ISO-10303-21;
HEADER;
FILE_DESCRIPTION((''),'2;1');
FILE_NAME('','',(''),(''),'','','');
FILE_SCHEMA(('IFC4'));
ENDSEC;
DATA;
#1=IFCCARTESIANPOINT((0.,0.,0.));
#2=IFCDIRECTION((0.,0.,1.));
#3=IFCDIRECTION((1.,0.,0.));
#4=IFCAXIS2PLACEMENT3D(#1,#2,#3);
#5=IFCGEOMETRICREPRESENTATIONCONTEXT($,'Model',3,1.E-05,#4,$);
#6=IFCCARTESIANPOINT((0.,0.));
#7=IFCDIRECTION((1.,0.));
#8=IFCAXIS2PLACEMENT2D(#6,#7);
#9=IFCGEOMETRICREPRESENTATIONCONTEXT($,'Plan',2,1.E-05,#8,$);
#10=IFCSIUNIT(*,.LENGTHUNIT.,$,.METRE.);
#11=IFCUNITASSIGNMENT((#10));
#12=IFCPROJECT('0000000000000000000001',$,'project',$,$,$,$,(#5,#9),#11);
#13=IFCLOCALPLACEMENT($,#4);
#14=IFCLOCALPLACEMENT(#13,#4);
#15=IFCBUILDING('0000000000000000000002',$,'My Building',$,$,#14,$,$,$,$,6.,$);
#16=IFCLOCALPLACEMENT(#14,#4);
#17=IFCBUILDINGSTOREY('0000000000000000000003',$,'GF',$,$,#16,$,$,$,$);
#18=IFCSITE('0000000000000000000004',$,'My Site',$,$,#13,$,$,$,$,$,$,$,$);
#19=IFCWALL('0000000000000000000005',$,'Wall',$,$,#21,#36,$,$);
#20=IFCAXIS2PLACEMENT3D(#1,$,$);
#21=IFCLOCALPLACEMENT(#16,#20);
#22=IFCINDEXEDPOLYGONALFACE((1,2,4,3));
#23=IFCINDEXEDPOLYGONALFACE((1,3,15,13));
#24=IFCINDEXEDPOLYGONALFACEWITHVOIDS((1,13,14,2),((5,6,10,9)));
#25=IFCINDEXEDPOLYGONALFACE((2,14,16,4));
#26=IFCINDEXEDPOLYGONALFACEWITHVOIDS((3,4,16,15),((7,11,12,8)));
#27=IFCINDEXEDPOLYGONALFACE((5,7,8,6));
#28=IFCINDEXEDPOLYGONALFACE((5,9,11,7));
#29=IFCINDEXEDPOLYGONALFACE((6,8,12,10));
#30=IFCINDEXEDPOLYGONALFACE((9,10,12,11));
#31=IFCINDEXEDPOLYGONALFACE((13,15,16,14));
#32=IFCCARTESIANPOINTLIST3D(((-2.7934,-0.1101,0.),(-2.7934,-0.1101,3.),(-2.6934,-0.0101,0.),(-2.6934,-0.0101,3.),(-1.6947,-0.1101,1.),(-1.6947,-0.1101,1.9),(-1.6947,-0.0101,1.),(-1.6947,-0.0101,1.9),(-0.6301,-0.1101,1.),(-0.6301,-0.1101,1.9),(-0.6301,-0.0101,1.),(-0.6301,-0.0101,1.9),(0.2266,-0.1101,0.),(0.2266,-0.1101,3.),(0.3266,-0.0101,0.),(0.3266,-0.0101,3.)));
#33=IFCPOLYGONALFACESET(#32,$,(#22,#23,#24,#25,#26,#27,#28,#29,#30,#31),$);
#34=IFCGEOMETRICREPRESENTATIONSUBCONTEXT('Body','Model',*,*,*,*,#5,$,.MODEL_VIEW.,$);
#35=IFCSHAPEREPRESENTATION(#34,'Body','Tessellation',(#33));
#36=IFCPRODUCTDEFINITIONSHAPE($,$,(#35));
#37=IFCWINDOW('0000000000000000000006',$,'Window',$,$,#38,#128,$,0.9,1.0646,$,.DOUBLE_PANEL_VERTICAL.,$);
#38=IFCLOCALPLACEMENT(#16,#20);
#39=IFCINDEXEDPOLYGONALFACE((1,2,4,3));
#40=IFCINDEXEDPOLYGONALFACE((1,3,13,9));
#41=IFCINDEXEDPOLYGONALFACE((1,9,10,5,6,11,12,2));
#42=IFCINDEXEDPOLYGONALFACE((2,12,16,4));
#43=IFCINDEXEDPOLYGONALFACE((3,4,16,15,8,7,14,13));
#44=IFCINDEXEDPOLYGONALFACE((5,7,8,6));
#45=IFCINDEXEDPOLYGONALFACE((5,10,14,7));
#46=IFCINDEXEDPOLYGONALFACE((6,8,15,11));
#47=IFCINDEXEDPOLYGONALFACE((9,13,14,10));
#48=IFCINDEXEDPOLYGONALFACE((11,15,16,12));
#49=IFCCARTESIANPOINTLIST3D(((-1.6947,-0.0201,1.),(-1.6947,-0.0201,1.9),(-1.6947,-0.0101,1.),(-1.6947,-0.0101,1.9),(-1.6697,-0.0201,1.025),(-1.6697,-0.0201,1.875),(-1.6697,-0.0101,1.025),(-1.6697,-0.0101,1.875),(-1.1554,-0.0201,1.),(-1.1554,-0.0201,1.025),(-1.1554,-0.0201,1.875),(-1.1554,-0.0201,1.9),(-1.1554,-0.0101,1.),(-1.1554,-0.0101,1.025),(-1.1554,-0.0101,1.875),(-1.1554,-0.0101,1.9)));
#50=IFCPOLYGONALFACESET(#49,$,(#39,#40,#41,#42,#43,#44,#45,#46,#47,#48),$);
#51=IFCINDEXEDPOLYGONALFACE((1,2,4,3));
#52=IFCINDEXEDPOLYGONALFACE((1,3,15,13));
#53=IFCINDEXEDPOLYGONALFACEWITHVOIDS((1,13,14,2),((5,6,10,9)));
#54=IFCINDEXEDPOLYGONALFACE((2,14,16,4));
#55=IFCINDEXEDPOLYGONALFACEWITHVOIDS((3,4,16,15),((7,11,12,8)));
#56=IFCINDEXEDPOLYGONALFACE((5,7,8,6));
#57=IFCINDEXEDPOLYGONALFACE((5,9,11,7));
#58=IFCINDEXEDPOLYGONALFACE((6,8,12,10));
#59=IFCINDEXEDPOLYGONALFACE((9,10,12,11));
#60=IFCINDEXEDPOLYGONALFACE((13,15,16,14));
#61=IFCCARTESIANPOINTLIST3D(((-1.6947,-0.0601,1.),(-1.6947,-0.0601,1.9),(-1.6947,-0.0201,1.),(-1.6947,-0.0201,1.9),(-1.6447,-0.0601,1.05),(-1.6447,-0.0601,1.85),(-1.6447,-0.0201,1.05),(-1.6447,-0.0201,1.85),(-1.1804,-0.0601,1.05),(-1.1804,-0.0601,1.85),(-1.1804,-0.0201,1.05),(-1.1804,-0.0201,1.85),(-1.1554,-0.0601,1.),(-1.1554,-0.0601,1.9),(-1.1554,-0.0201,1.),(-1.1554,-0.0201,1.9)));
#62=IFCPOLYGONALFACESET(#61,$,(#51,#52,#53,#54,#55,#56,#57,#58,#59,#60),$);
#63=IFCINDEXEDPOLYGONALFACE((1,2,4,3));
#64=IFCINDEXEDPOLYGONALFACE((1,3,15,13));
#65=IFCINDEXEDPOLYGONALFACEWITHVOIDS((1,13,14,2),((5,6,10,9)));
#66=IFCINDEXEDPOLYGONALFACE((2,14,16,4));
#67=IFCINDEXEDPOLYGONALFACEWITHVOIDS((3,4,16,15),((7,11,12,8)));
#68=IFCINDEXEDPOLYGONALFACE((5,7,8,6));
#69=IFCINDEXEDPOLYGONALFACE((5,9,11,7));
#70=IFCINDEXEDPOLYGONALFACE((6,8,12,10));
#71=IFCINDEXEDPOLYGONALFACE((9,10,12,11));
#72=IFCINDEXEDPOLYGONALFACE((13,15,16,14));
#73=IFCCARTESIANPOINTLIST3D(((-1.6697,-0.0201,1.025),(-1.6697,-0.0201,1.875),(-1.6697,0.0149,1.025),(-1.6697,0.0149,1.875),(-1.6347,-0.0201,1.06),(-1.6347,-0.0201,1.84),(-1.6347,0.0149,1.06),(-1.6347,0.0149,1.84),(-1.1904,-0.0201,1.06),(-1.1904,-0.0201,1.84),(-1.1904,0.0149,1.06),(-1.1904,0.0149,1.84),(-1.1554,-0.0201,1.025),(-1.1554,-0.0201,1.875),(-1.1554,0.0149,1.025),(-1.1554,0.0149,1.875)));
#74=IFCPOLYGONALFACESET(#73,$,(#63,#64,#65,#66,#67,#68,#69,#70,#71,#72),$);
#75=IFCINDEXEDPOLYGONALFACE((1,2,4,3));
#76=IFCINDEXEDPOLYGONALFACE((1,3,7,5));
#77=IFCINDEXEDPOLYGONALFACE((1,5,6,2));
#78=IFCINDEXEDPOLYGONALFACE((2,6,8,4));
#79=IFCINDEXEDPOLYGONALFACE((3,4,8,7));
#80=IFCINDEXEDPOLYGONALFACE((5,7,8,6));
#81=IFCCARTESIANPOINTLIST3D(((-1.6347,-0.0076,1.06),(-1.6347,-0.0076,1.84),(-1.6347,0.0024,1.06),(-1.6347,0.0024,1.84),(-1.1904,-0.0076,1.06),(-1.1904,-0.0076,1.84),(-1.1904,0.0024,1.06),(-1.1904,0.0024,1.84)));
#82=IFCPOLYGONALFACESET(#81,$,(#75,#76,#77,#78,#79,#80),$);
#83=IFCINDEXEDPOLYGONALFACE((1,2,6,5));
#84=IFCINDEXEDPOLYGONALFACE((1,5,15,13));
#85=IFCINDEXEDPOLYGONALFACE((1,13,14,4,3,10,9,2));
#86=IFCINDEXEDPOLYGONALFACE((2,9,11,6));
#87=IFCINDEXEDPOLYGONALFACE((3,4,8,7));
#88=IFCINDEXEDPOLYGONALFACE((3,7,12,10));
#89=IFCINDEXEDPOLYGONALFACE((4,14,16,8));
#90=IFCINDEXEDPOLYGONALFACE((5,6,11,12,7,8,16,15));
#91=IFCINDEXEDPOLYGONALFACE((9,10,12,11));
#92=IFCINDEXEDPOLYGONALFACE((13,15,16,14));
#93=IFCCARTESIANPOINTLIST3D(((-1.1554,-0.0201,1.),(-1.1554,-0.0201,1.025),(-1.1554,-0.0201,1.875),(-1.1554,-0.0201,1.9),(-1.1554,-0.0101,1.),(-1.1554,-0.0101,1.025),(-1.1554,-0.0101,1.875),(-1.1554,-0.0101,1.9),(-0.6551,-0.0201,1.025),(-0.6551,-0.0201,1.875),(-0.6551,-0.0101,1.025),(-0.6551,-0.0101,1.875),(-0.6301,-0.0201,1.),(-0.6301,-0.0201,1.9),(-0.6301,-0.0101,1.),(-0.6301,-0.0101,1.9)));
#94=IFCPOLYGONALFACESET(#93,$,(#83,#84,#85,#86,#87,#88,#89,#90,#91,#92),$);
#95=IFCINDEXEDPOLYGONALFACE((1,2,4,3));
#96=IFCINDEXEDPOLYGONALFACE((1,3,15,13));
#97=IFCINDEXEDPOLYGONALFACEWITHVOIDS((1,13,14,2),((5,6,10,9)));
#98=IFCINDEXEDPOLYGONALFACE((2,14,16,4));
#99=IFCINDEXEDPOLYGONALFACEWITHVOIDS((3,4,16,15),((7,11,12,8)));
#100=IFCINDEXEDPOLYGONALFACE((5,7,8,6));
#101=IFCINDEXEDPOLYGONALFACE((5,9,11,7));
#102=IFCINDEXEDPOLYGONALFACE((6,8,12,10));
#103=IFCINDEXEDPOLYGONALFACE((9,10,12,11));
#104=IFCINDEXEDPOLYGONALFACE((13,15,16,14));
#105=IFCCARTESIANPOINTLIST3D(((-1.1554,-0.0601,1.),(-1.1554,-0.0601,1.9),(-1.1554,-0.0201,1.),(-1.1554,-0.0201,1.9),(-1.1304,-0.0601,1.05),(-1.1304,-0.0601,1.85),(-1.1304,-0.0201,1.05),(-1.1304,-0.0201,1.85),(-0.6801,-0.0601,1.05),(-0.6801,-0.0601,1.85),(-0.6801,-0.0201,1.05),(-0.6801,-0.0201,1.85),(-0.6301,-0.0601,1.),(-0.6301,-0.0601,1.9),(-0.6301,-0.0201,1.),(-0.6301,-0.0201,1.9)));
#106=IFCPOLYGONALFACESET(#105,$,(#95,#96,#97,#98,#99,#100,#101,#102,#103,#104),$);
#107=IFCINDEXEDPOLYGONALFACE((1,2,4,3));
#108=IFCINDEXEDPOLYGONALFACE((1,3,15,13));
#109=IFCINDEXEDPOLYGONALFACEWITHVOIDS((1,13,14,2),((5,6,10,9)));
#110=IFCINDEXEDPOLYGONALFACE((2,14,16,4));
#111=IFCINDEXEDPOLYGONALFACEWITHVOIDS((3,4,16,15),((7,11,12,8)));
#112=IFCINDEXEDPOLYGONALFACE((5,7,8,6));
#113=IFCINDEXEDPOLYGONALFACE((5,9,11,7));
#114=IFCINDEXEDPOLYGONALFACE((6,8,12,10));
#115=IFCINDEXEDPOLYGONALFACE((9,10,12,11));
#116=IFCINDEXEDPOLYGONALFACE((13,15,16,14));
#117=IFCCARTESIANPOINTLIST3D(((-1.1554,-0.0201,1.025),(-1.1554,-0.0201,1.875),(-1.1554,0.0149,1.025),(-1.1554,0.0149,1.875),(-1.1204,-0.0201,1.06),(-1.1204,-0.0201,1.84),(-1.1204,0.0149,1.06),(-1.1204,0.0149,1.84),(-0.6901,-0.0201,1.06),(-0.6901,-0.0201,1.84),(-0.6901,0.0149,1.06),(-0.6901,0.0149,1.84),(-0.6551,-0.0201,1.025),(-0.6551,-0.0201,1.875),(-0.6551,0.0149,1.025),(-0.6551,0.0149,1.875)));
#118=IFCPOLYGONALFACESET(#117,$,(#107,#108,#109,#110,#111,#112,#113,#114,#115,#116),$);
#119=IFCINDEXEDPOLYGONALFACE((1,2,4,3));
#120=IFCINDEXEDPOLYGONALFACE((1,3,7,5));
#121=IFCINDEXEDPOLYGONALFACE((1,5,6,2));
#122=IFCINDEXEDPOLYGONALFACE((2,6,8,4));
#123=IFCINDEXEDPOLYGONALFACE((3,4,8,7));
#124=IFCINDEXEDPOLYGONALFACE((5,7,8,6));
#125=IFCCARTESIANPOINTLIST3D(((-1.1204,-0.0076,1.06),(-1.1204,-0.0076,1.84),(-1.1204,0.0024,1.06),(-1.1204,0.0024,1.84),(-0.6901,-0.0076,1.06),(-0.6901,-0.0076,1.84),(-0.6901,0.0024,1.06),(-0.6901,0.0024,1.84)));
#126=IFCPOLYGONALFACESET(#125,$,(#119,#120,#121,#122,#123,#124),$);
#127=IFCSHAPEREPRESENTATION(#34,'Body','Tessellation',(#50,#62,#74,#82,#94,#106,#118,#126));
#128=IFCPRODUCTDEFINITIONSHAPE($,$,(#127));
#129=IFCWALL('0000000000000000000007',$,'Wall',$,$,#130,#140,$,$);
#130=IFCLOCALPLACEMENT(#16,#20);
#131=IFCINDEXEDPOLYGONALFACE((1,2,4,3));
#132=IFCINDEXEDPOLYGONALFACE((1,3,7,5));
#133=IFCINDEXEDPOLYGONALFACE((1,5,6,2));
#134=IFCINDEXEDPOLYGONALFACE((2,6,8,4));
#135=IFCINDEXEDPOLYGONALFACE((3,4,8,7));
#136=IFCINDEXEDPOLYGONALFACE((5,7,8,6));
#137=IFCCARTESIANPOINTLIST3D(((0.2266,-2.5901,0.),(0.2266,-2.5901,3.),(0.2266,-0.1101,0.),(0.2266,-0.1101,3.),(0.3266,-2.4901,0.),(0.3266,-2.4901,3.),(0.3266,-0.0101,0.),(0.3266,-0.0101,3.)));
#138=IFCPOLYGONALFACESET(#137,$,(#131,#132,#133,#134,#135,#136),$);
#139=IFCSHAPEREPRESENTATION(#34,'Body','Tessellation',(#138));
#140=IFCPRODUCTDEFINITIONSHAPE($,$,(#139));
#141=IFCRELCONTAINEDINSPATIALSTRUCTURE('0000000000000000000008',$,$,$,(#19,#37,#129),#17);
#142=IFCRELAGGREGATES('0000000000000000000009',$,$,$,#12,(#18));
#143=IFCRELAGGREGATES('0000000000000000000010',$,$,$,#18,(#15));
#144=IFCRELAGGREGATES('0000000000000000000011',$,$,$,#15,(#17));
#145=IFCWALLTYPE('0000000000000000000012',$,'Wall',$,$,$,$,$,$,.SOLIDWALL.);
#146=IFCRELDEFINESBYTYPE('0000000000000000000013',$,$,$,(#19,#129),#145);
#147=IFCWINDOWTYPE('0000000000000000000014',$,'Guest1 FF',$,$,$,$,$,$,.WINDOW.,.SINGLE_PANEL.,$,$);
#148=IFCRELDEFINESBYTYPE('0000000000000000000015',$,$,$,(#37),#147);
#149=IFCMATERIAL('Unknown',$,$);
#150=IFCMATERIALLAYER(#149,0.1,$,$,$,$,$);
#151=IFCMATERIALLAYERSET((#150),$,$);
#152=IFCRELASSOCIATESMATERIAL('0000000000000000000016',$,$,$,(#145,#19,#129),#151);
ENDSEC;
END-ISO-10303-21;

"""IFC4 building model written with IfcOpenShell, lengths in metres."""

from ifc_helpers import new_model, entity, si_unit, frame, origin_with_axes, origin_2d_with_axis, place, context, subcontext, project, spatial, line, indexed_curve, outline, extrude, shape, source, transform, mapped, material, layer, layer_set, layer_usage, type_object, type_shapes, element, fill, save


model = new_model("IFC4")

# Units and contexts
model_context = context("Model", 3, precision=1e-05, world=origin_with_axes())
plan_context = context("Plan", 2, precision=1e-05, world=origin_2d_with_axis())
body_context_1 = subcontext(model_context, "Body", "Model", "MODEL_VIEW")
body_context_2 = subcontext(plan_context, "Body", "Plan", "PLAN_VIEW")
ifc_project = project(units=[si_unit("LENGTHUNIT", "METRE")], contexts=[model_context, plan_context])

# Site, building, storey
site_placement = place(None, origin_with_axes())
site = spatial("IfcSite", under=ifc_project, at=site_placement, Name="My Site")
building_placement = place(site_placement, origin_with_axes())
building = spatial("IfcBuilding", under=site, at=building_placement, Name="My Building", ElevationOfTerrain=6.0)
storey_placement = place(building_placement, origin_with_axes())
storey = spatial("IfcBuildingStorey", under=building, at=storey_placement, Name="GF")

# Shared definitions
ifc_material_1 = material(Name="Unknown")
ifc_layer = layer(ifc_material_1, 0.1)
ifc_layer_set = layer_set([ifc_layer])
wall_type = type_object("IfcWallType", Name="Wall", PredefinedType="SOLIDWALL", material=ifc_layer_set)

# Wall, opening, window
ifc_layer_usage_1 = layer_usage(ifc_layer_set, "AXIS2", "POSITIVE", 0.0)
wall_1_placement = place(storey_placement, frame((-2.7934, -0.1101, 0.0), z_axis=(0.0, 0.0, 1.0), x_axis=(1.0, 0.0, 0.0)))
wall_1 = element("IfcWall", 1, at=wall_1_placement, inside=storey, type_object=wall_type, material=ifc_layer_usage_1, Name="Wall", context=body_context_1, shape_type="SweptSolid", body=[
    extrude(outline(indexed_curve([(0.0, 0.0), (0.1, 0.1), (3.12, 0.1), (3.02, 0.0)], segments=[line(1, 2, 3, 4, 1)])), origin_with_axes(), (0.0, 0.0, 1.0), 3.0),
])
shared_shape_1 = source(origin_with_axes(), body_context_1, "Body", "SweptSolid", [
    extrude(outline(indexed_curve([(0.0, 0.0), (1.0646, 0.0), (1.0646, 0.9), (0.0, 0.9)], segments=[line(1, 2, 3, 4, 1)])), frame((0.0, -0.6, 0.0), z_axis=(0.0, -1.0, 0.0), x_axis=(1.0, 0.0, 0.0)), (0.0, 0.0, -1.0), 1.2),
])
opening_1_placement = place(wall_1_placement, frame((1.0987, 0.0, 1.0), z_axis=(0.0, 0.0, 1.0), x_axis=(1.0, 0.0, 0.0)))
opening_1 = element("IfcOpeningElement", 2, at=opening_1_placement, cuts=wall_1, PredefinedType="OPENING", context=body_context_1, shape_type="MappedRepresentation", body=[
    mapped(shared_shape_1, transform((0.0, 0.0, 0.0), x_axis=(1.0, 0.0, 0.0), y_axis=(0.0, 1.0, 0.0), z_axis=(0.0, 0.0, 1.0), scale=1.0)),
])
window_type_1 = type_object("IfcWindowType", Name="Guest1 FF", PartitioningType="SINGLE_PANEL", PredefinedType="WINDOW")
shared_shape_2 = source(origin_with_axes(), body_context_1, "Body", "SweptSolid", [
    extrude(outline(indexed_curve([(0.5393, 0.0), (0.0, 0.0), (0.0, 0.9), (0.5393, 0.9), (0.5393, 0.875), (0.025, 0.875), (0.025, 0.025), (0.5393, 0.025)], segments=[line(1, 2, 3, 4, 5, 6, 7, 8, 1)])), frame((0.0, 0.09, 0.0), z_axis=(0.0, -1.0, 0.0), x_axis=(1.0, 0.0, 0.0)), (0.0, 0.0, -1.0), 0.01),
    extrude(outline(indexed_curve([(0.0, 0.0), (0.5393, 0.0), (0.5393, 0.9), (0.0, 0.9)], segments=[line(1, 2, 3, 4, 1)]), holes=[indexed_curve([(0.05, 0.05), (0.5143, 0.05), (0.5143, 0.85), (0.05, 0.85)], segments=[line(1, 2, 3, 4, 1)])]), frame((0.0, 0.05, 0.0), z_axis=(0.0, -1.0, 0.0), x_axis=(1.0, 0.0, 0.0)), (0.0, 0.0, -1.0), 0.04),
    extrude(outline(indexed_curve([(0.0, 0.0), (0.5143, 0.0), (0.5143, 0.85), (0.0, 0.85)], segments=[line(1, 2, 3, 4, 1)]), holes=[indexed_curve([(0.035, 0.035), (0.4793, 0.035), (0.4793, 0.815), (0.035, 0.815)], segments=[line(1, 2, 3, 4, 1)])]), frame((0.025, 0.09, 0.025), z_axis=(0.0, -1.0, 0.0), x_axis=(1.0, 0.0, 0.0)), (0.0, 0.0, -1.0), 0.035),
    extrude(outline(indexed_curve([(0.035, 0.035), (0.4793, 0.035), (0.4793, 0.815), (0.035, 0.815)], segments=[line(1, 2, 3, 4, 1)])), frame((0.025, 0.1025, 0.025), z_axis=(0.0, -1.0, 0.0), x_axis=(1.0, 0.0, 0.0)), (0.0, 0.0, -1.0), 0.01),
    extrude(outline(indexed_curve([(0.0, 0.9), (0.5253, 0.9), (0.5253, 0.0), (0.0, 0.0), (0.0, 0.025), (0.5003, 0.025), (0.5003, 0.875), (0.0, 0.875)], segments=[line(1, 2, 3, 4, 5, 6, 7, 8, 1)])), frame((0.5393, 0.09, 0.0), z_axis=(0.0, -1.0, 0.0), x_axis=(1.0, 0.0, 0.0)), (0.0, 0.0, -1.0), 0.01),
    extrude(outline(indexed_curve([(0.0, 0.0), (0.5253, 0.0), (0.5253, 0.9), (0.0, 0.9)], segments=[line(1, 2, 3, 4, 1)]), holes=[indexed_curve([(0.025, 0.05), (0.4753, 0.05), (0.4753, 0.85), (0.025, 0.85)], segments=[line(1, 2, 3, 4, 1)])]), frame((0.5393, 0.05, 0.0), z_axis=(0.0, -1.0, 0.0), x_axis=(1.0, 0.0, 0.0)), (0.0, 0.0, -1.0), 0.04),
    extrude(outline(indexed_curve([(0.0, 0.0), (0.5003, 0.0), (0.5003, 0.85), (0.0, 0.85)], segments=[line(1, 2, 3, 4, 1)]), holes=[indexed_curve([(0.035, 0.035), (0.4653, 0.035), (0.4653, 0.815), (0.035, 0.815)], segments=[line(1, 2, 3, 4, 1)])]), frame((0.5393, 0.09, 0.025), z_axis=(0.0, -1.0, 0.0), x_axis=(1.0, 0.0, 0.0)), (0.0, 0.0, -1.0), 0.035),
    extrude(outline(indexed_curve([(0.035, 0.035), (0.4653, 0.035), (0.4653, 0.815), (0.035, 0.815)], segments=[line(1, 2, 3, 4, 1)])), frame((0.5393, 0.1025, 0.025), z_axis=(0.0, -1.0, 0.0), x_axis=(1.0, 0.0, 0.0)), (0.0, 0.0, -1.0), 0.01),
])
shared_shape_3 = source(origin_with_axes(), body_context_2, "Body", "Curve2D", [
    entity("IfcIndexedPolyCurve", entity("IfcCartesianPointList2D", [[0.05, 0.05], [0.5143, 0.05]])),
    entity("IfcIndexedPolyCurve", entity("IfcCartesianPointList2D", [[0.0, 0.1], [0.025, 0.1], [0.025, 0.09], [0.05, 0.09], [0.05, 0.05], [0.0, 0.05]]), [entity("IfcLineIndex", [1, 2, 3, 4, 5, 6, 1])]),
    entity("IfcIndexedPolyCurve", entity("IfcCartesianPointList2D", [[0.5393, 0.1], [0.5393, 0.1], [0.5393, 0.09], [0.5143, 0.09], [0.5143, 0.05], [0.5393, 0.05]])),
    entity("IfcIndexedPolyCurve", entity("IfcCartesianPointList2D", [[0.025, 0.09], [0.06, 0.09], [0.06, 0.125], [0.025, 0.125]]), [entity("IfcLineIndex", [1, 2, 3, 4, 1])]),
    entity("IfcIndexedPolyCurve", entity("IfcCartesianPointList2D", [[0.5393, 0.09], [0.5043, 0.09], [0.5043, 0.125], [0.5393, 0.125]]), [entity("IfcLineIndex", [1, 2, 3, 4, 1])]),
    entity("IfcIndexedPolyCurve", entity("IfcCartesianPointList2D", [[0.06, 0.09], [0.5043, 0.09]])),
    entity("IfcIndexedPolyCurve", entity("IfcCartesianPointList2D", [[0.06, 0.125], [0.5043, 0.125]])),
    entity("IfcIndexedPolyCurve", entity("IfcCartesianPointList2D", [[0.06, 0.1075], [0.5043, 0.1075]])),
    entity("IfcIndexedPolyCurve", entity("IfcCartesianPointList2D", [[0.5643, 0.05], [1.0146, 0.05]])),
    entity("IfcIndexedPolyCurve", entity("IfcCartesianPointList2D", [[0.5393, 0.1], [0.5393, 0.1], [0.5393, 0.09], [0.5643, 0.09], [0.5643, 0.05], [0.5393, 0.05]])),
    entity("IfcIndexedPolyCurve", entity("IfcCartesianPointList2D", [[1.0646, 0.1], [1.0396, 0.1], [1.0396, 0.09], [1.0146, 0.09], [1.0146, 0.05], [1.0646, 0.05]]), [entity("IfcLineIndex", [1, 2, 3, 4, 5, 6, 1])]),
    entity("IfcIndexedPolyCurve", entity("IfcCartesianPointList2D", [[0.5393, 0.09], [0.5743, 0.09], [0.5743, 0.125], [0.5393, 0.125]]), [entity("IfcLineIndex", [1, 2, 3, 4, 1])]),
    entity("IfcIndexedPolyCurve", entity("IfcCartesianPointList2D", [[1.0396, 0.09], [1.0046, 0.09], [1.0046, 0.125], [1.0396, 0.125]]), [entity("IfcLineIndex", [1, 2, 3, 4, 1])]),
    entity("IfcIndexedPolyCurve", entity("IfcCartesianPointList2D", [[0.5743, 0.09], [1.0046, 0.09]])),
    entity("IfcIndexedPolyCurve", entity("IfcCartesianPointList2D", [[0.5743, 0.125], [1.0046, 0.125]])),
    entity("IfcIndexedPolyCurve", entity("IfcCartesianPointList2D", [[0.5743, 0.1075], [1.0046, 0.1075]])),
])
type_shapes(window_type_1, [shared_shape_2, shared_shape_3])
window_1_placement = place(opening_1_placement, origin_with_axes())
window_1 = element("IfcWindow", 3, at=window_1_placement, inside=storey, type_object=window_type_1, Name="Window", OverallHeight=0.9, OverallWidth=1.0646, PartitioningType="DOUBLE_PANEL_VERTICAL", shapes=[
    shape(body_context_1, "Body", "MappedRepresentation", [mapped(shared_shape_2, transform((0.0, 0.0, 0.0), x_axis=(1.0, 0.0, 0.0), y_axis=(0.0, 1.0, 0.0), z_axis=(0.0, 0.0, 1.0), scale=1.0))]),
    shape(body_context_2, "Body", "MappedRepresentation", [mapped(shared_shape_3, transform((0.0, 0.0, 0.0), x_axis=(1.0, 0.0, 0.0), y_axis=(0.0, 1.0, 0.0), z_axis=(0.0, 0.0, 1.0), scale=1.0))]),
])
fill(opening_1, window_1)

# Wall
ifc_layer_usage_2 = layer_usage(ifc_layer_set, "AXIS2", "POSITIVE", 0.0)
wall_2_placement = place(storey_placement, frame((0.2266, -0.1101, 0.0), z_axis=(0.0, 0.0, 1.0), x_axis=(0.0, -1.0, 0.0)))
element("IfcWall", 4, at=wall_2_placement, inside=storey, type_object=wall_type, material=ifc_layer_usage_2, Name="Wall", context=body_context_1, shape_type="SweptSolid", body=[
    extrude(outline(indexed_curve([(0.0, 0.0), (-0.1, 0.1), (2.38, 0.1), (2.48, 0.0)], segments=[line(1, 2, 3, 4, 1)])), origin_with_axes(), (0.0, 0.0, 1.0), 3.0),
])

save(model, "model.ifc")
